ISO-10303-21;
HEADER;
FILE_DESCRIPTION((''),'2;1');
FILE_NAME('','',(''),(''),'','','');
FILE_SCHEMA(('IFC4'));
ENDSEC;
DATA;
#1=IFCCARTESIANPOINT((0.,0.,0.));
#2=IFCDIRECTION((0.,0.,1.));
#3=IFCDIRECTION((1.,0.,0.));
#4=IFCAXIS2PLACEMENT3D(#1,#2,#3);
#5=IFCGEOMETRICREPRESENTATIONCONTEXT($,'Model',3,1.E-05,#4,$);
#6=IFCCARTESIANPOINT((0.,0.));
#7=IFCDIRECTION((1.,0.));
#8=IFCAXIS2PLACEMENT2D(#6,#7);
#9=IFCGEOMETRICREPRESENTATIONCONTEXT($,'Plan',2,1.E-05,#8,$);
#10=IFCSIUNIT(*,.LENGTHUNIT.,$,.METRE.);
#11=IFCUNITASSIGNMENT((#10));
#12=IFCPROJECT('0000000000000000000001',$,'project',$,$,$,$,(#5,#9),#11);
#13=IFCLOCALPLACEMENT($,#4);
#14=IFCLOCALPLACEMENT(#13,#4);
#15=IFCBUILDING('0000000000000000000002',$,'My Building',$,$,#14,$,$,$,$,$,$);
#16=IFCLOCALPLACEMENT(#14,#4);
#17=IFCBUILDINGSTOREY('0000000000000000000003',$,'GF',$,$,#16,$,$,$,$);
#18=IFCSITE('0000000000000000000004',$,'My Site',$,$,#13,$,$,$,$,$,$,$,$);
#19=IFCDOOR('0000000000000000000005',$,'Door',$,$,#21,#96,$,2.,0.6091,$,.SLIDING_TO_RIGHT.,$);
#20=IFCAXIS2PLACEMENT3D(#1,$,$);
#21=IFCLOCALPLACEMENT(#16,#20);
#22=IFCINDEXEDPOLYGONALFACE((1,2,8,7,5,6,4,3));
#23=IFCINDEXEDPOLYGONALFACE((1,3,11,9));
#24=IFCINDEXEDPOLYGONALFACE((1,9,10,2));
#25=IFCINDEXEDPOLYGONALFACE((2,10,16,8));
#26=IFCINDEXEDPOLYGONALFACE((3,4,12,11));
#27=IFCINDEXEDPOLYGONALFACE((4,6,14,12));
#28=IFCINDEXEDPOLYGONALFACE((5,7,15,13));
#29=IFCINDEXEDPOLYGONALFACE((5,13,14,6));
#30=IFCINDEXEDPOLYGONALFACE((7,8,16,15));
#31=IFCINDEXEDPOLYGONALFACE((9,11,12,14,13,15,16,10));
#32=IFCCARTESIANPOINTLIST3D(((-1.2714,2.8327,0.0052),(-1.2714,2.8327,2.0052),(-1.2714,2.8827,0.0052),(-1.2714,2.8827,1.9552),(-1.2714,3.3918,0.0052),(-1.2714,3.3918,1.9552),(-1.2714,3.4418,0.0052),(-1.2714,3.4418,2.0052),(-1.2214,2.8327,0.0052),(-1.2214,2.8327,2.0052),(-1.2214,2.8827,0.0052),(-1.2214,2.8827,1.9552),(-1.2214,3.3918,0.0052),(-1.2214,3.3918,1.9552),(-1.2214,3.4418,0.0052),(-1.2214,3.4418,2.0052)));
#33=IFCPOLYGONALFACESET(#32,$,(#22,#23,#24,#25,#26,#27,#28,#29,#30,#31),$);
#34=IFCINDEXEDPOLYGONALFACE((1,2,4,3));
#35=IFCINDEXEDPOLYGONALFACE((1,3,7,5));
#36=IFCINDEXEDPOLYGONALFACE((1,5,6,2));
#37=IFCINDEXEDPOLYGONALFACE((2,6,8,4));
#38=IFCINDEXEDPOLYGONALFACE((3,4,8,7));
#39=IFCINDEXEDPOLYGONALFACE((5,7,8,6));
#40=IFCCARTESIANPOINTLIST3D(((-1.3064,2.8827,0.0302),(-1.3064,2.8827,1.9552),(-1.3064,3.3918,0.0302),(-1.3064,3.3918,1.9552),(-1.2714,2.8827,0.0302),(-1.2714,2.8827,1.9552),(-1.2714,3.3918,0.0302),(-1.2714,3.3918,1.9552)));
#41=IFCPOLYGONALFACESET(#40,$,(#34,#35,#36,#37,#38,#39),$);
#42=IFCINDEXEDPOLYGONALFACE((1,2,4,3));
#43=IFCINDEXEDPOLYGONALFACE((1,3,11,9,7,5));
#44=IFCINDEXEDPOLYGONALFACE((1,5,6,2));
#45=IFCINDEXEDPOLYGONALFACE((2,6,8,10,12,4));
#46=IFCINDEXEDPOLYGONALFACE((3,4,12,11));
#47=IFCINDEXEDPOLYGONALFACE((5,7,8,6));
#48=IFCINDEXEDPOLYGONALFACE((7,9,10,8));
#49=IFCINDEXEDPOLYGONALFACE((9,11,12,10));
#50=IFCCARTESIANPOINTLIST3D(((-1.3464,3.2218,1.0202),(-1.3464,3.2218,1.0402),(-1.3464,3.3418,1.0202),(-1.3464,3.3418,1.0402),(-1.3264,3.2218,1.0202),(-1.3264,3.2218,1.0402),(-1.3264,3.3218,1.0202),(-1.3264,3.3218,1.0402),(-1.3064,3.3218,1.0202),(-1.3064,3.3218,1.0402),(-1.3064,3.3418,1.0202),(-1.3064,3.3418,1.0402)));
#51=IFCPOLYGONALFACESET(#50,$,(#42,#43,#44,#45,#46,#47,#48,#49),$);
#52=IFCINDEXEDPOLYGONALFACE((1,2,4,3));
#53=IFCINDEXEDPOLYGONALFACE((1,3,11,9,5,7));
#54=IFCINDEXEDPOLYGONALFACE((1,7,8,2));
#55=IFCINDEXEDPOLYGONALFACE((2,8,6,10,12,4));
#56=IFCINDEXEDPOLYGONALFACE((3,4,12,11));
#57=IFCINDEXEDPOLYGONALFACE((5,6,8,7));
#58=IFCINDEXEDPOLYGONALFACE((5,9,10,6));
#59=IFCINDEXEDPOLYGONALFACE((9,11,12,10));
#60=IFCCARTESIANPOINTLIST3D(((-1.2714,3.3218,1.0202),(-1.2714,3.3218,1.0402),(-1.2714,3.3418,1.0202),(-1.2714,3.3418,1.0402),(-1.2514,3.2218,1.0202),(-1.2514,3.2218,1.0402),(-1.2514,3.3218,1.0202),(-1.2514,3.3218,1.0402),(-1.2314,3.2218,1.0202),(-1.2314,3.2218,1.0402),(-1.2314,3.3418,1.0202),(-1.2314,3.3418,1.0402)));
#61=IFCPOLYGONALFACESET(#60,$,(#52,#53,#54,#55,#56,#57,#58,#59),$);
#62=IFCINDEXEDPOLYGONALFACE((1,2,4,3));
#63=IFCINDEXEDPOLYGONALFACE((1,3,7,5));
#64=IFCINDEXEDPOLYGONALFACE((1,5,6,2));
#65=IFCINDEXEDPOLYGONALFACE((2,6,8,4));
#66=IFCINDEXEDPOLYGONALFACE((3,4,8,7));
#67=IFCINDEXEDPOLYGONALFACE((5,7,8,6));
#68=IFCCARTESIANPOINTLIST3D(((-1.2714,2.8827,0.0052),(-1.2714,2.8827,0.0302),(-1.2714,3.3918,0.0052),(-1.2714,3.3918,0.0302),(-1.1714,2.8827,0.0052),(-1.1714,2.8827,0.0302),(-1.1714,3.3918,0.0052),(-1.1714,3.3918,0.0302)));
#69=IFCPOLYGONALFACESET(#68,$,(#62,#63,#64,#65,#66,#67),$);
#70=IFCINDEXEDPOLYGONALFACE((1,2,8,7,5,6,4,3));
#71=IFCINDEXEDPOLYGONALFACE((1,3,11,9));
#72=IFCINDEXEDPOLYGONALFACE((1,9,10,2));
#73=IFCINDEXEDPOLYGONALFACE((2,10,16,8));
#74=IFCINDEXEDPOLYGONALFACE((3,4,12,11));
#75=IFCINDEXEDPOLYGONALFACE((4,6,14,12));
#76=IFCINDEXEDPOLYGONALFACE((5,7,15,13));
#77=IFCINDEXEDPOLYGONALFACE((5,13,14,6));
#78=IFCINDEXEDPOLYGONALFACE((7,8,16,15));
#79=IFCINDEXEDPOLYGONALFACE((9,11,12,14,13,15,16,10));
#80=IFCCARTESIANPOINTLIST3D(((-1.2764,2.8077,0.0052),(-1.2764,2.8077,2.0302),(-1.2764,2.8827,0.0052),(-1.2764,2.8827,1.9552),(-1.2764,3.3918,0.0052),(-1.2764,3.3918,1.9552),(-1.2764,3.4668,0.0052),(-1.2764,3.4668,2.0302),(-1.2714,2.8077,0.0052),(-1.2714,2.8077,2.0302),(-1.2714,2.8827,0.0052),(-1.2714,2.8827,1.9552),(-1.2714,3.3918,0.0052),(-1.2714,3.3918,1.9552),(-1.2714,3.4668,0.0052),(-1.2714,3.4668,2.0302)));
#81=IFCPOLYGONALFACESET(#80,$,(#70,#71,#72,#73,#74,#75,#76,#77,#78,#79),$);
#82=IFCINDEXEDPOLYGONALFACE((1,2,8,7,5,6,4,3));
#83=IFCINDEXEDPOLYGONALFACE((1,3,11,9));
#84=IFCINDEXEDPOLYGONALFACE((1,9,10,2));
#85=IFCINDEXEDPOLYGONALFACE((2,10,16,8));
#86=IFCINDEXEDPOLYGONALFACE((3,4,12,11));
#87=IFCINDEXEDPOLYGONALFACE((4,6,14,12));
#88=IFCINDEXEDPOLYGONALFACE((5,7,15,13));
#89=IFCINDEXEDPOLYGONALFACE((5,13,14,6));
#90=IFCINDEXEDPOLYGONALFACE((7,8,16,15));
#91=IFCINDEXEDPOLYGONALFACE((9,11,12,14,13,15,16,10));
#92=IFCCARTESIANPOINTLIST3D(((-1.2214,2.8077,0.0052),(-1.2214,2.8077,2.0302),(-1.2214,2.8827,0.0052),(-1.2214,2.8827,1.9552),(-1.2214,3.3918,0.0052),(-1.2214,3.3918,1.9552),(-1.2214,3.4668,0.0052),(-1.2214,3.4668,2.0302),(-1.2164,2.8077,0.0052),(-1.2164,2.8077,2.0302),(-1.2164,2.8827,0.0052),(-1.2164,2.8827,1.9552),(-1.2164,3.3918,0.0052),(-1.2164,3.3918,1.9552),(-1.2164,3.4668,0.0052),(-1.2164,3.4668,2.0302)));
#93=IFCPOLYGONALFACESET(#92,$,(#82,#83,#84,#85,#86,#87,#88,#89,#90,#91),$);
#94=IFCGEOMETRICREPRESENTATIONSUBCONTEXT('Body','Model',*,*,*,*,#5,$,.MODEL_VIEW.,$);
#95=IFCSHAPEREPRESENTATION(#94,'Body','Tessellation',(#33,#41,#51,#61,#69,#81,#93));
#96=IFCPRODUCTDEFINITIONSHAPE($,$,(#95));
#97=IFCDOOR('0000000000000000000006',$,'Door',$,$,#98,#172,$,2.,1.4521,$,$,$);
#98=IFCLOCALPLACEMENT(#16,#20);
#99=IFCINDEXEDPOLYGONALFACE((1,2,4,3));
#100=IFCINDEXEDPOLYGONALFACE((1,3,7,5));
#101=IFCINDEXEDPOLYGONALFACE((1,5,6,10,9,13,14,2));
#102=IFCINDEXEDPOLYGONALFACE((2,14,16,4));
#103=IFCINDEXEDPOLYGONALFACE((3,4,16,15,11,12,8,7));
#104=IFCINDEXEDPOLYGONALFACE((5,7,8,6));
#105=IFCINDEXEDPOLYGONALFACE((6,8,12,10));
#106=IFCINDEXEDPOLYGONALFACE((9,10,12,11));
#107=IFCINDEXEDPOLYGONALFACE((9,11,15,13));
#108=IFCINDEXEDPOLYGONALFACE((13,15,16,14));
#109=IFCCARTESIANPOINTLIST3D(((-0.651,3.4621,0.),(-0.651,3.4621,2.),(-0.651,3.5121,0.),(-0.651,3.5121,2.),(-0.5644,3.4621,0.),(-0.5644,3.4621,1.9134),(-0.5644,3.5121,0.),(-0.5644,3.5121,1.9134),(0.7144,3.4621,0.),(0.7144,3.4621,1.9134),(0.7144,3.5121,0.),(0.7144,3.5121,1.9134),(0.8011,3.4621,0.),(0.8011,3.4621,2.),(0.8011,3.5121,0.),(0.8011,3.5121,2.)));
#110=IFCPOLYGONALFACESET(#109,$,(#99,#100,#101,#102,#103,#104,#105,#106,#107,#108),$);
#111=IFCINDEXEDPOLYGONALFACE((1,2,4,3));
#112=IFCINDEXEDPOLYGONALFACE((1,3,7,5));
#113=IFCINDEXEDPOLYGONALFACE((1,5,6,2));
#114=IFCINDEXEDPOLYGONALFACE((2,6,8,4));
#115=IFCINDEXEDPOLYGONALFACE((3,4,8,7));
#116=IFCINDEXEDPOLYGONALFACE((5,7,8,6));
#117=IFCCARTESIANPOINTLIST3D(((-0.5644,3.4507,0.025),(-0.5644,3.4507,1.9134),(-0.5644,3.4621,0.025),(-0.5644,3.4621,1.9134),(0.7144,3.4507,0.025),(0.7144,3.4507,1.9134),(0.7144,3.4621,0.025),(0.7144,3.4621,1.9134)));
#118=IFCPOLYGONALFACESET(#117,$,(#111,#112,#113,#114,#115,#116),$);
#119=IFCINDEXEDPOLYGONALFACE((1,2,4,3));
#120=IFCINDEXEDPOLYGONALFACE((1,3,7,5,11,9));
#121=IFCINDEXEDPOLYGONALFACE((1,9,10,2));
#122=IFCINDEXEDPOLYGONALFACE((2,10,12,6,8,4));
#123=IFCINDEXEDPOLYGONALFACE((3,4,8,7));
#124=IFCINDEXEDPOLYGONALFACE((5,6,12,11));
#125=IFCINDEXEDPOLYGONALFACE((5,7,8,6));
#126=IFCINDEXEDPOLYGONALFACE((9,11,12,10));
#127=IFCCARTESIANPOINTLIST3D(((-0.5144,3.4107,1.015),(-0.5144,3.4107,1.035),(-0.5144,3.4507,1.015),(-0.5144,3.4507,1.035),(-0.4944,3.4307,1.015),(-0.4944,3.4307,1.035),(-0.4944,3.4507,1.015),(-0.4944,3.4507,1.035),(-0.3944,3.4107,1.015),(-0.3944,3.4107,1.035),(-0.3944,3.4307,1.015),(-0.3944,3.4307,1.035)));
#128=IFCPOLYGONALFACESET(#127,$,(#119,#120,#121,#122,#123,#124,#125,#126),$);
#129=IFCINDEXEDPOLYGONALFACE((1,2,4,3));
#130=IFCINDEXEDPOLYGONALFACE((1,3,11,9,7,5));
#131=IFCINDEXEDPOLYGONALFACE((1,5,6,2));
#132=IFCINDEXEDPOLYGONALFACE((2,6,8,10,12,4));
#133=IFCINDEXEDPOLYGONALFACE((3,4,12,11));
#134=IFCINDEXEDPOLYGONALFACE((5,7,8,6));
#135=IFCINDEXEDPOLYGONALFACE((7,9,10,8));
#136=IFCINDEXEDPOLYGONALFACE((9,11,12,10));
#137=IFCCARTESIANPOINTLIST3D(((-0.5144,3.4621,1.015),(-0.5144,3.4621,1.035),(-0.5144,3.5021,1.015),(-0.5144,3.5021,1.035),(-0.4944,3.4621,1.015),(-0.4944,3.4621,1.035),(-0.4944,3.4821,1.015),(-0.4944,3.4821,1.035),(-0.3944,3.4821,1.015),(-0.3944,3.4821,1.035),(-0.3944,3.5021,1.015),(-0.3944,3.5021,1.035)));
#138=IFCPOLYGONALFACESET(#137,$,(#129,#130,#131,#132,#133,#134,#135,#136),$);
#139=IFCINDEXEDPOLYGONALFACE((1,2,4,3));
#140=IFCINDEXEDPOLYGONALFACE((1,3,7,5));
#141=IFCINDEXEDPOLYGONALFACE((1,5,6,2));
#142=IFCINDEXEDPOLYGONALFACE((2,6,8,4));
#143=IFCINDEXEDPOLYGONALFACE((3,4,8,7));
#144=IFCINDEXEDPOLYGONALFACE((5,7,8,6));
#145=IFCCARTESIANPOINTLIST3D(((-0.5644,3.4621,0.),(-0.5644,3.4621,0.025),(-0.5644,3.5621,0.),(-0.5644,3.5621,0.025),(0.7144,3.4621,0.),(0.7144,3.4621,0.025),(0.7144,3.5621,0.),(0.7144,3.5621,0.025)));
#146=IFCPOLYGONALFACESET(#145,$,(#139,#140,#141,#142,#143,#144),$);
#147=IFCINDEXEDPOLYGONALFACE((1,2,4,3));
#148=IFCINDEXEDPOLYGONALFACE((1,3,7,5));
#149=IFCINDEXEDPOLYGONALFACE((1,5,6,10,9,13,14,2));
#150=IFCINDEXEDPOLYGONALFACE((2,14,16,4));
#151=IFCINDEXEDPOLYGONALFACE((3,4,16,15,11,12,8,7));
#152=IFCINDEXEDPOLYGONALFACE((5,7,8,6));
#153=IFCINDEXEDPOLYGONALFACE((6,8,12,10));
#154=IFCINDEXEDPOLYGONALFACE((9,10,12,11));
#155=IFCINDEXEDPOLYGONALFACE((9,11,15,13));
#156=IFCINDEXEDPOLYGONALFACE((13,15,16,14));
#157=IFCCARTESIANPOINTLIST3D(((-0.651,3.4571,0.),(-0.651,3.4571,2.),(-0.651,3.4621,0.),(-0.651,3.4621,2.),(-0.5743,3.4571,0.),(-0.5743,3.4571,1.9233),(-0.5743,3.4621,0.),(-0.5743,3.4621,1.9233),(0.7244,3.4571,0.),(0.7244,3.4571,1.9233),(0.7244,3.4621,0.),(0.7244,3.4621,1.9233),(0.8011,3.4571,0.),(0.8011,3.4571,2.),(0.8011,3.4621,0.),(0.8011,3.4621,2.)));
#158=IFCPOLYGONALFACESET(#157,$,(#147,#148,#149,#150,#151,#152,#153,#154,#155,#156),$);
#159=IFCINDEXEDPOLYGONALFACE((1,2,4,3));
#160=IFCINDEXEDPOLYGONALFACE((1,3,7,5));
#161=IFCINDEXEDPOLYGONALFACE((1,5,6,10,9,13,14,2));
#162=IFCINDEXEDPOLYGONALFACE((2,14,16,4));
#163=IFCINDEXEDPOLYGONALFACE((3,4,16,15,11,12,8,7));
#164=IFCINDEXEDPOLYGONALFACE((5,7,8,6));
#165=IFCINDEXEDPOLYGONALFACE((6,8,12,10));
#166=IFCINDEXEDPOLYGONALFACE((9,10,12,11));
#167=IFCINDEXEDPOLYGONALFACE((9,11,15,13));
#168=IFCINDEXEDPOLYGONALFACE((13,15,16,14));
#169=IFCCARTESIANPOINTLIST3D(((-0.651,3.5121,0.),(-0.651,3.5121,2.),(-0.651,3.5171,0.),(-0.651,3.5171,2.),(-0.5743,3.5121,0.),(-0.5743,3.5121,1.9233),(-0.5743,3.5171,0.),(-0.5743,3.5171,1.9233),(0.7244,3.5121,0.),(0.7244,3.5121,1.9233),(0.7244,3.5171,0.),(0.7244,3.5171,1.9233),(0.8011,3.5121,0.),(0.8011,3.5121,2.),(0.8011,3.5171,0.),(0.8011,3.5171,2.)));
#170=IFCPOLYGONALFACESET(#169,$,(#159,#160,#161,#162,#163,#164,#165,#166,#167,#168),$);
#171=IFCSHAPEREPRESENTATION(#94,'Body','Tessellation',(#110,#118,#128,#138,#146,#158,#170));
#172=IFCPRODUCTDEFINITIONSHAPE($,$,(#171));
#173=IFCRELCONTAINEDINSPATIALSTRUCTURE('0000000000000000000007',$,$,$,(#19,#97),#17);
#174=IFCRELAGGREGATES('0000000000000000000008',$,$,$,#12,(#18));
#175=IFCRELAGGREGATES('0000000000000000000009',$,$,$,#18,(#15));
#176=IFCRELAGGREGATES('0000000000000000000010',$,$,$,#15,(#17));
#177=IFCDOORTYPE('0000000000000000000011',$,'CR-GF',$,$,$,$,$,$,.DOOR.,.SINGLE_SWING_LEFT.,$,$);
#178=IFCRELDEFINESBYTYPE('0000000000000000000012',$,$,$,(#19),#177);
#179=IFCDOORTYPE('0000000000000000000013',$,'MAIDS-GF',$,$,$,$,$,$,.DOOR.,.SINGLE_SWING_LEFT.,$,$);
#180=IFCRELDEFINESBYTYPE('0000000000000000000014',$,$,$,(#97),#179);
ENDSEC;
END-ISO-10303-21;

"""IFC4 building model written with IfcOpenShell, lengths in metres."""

from ifc_helpers import new_model, entity, si_unit, frame, origin_with_axes, origin_2d_with_axis, place, context, subcontext, project, spatial, line, indexed_curve, outline, extrude, shape, source, transform, mapped, type_object, type_shapes, element, save


model = new_model("IFC4")

# Units and contexts
model_context = context("Model", 3, precision=1e-05, world=origin_with_axes())
plan_context = context("Plan", 2, precision=1e-05, world=origin_2d_with_axis())
body_context_1 = subcontext(model_context, "Body", "Model", "MODEL_VIEW")
body_context_2 = subcontext(plan_context, "Body", "Plan", "PLAN_VIEW")
ifc_project = project(units=[si_unit("LENGTHUNIT", "METRE")], contexts=[model_context, plan_context])

# Site, building, storey
site_placement = place(None, origin_with_axes())
site = spatial("IfcSite", under=ifc_project, at=site_placement, Name="My Site")
building_placement = place(site_placement, origin_with_axes())
building = spatial("IfcBuilding", under=site, at=building_placement, Name="My Building")
storey_placement = place(building_placement, origin_with_axes())
storey = spatial("IfcBuildingStorey", under=building, at=storey_placement, Name="GF")

# Shared definitions
wall_1_placement = place(storey_placement, frame((0.7783, 3.5621, 0.0), z_axis=(0.0, 0.0, 1.0), x_axis=(-1.0, 0.0, 0.0)))
door_type_1 = type_object("IfcDoorType", Name="MAIDS-GF", OperationType="SINGLE_SWING_LEFT", PredefinedType="DOOR")
shared_shape_1 = source(origin_with_axes(), body_context_1, "Body", "SweptSolid", [
    extrude(outline(indexed_curve([(0.0, 0.0), (0.0, 2.0), (1.4521, 2.0), (1.4521, 0.0), (1.3655, 0.0), (1.3655, 1.9134), (0.0866, 1.9134), (0.0866, 0.0)], segments=[line(1, 2, 3, 4, 5, 6, 7, 8, 1)])), frame((0.0, 0.0, 0.0), z_axis=(0.0, -1.0, 0.0), x_axis=(1.0, 0.0, 0.0)), (0.0, 0.0, -1.0), 0.05),
    extrude(outline(indexed_curve([(0.0, 0.0), (1.2788, 0.0), (1.2788, 0.0114), (0.0, 0.0114)], segments=[line(1, 2, 3, 4, 1)])), frame((0.0866, -0.0114, 0.025), z_axis=(0.0, 0.0, 1.0), x_axis=(1.0, 0.0, 0.0)), (0.0, 0.0, 1.0), 1.8884),
    extrude(outline(indexed_curve([(0.0, 0.0), (0.0, -0.04), (0.12, -0.04), (0.12, -0.02), (0.02, -0.02), (0.02, 0.0)], segments=[line(1, 2, 3, 4, 5, 6, 1)])), frame((0.1366, -0.0114, 1.015), z_axis=(0.0, 0.0, 1.0), x_axis=(1.0, 0.0, 0.0)), (0.0, 0.0, 1.0), 0.02),
    extrude(outline(indexed_curve([(0.0, 0.0), (0.0, 0.04), (0.12, 0.04), (0.12, 0.02), (0.02, 0.02), (0.02, 0.0)], segments=[line(1, 2, 3, 4, 5, 6, 1)])), frame((0.1366, 0.0, 1.015), z_axis=(0.0, 0.0, 1.0), x_axis=(1.0, 0.0, 0.0)), (0.0, 0.0, 1.0), 0.02),
    extrude(outline(indexed_curve([(0.0, 0.0), (1.2788, 0.0), (1.2788, 0.1), (0.0, 0.1)], segments=[line(1, 2, 3, 4, 1)])), frame((0.0866, 0.0, 0.0), z_axis=(0.0, 0.0, 1.0), x_axis=(1.0, 0.0, 0.0)), (0.0, 0.0, 1.0), 0.025),
    extrude(outline(indexed_curve([(0.0, 0.0), (0.0, 2.0), (1.4521, 2.0), (1.4521, 0.0), (1.3754, 0.0), (1.3754, 1.9233), (0.0767, 1.9233), (0.0767, 0.0)], segments=[line(1, 2, 3, 4, 5, 6, 7, 8, 1)])), frame((0.0, -0.005, 0.0), z_axis=(0.0, -1.0, 0.0), x_axis=(1.0, 0.0, 0.0)), (0.0, 0.0, -1.0), 0.005),
    extrude(outline(indexed_curve([(0.0, 0.0), (0.0, 2.0), (1.4521, 2.0), (1.4521, 0.0), (1.3754, 0.0), (1.3754, 1.9233), (0.0767, 1.9233), (0.0767, 0.0)], segments=[line(1, 2, 3, 4, 5, 6, 7, 8, 1)])), frame((0.0, 0.05, 0.0), z_axis=(0.0, -1.0, 0.0), x_axis=(1.0, 0.0, 0.0)), (0.0, 0.0, -1.0), 0.005),
])
shared_shape_2 = source(origin_with_axes(), body_context_2, "Body", "Curve2D", [
    entity("IfcIndexedPolyCurve", entity("IfcCartesianPointList2D", [[0.0, 0.0], [0.0866, 0.0], [0.0866, 0.05], [0.0, 0.05]]), [entity("IfcLineIndex", [1, 2, 3, 4, 1])]),
    entity("IfcIndexedPolyCurve", entity("IfcCartesianPointList2D", [[1.4521, 0.0], [1.3655, 0.0], [1.3655, 0.05], [1.4521, 0.05]]), [entity("IfcLineIndex", [1, 2, 3, 4, 1])]),
    entity("IfcIndexedPolyCurve", entity("IfcCartesianPointList2D", [[2.0049, -0.0114], [0.7261, -0.0114], [0.7261, 0.0], [2.0049, 0.0]]), [entity("IfcLineIndex", [1, 2, 3, 4, 1])]),
])
type_shapes(door_type_1, [shared_shape_1, shared_shape_2])

# Doors
door_type_2 = type_object("IfcDoorType", Name="CR-GF", OperationType="SINGLE_SWING_LEFT", PredefinedType="DOOR")
shared_shape_3 = source(origin_with_axes(), body_context_1, "Body", "SweptSolid", [
    extrude(outline(indexed_curve([(0.0, 0.0), (0.0, 2.0), (0.6091, 2.0), (0.6091, 0.0), (0.5591, 0.0), (0.5591, 1.95), (0.05, 1.95), (0.05, 0.0)], segments=[line(1, 2, 3, 4, 5, 6, 7, 8, 1)])), frame((0.0, 0.0, 0.0), z_axis=(0.0, -1.0, 0.0), x_axis=(1.0, 0.0, 0.0)), (0.0, 0.0, -1.0), 0.05),
    extrude(outline(indexed_curve([(0.0, 0.0), (0.5091, 0.0), (0.5091, 0.035), (0.0, 0.035)], segments=[line(1, 2, 3, 4, 1)])), frame((0.05, -0.035, 0.025), z_axis=(0.0, 0.0, 1.0), x_axis=(1.0, 0.0, 0.0)), (0.0, 0.0, 1.0), 1.925),
    extrude(outline(indexed_curve([(0.0, 0.0), (0.0, -0.04), (0.12, -0.04), (0.12, -0.02), (0.02, -0.02), (0.02, 0.0)], segments=[line(1, 2, 3, 4, 5, 6, 1)])), frame((0.1, -0.035, 1.015), z_axis=(0.0, 0.0, 1.0), x_axis=(1.0, 0.0, 0.0)), (0.0, 0.0, 1.0), 0.02),
    extrude(outline(indexed_curve([(0.0, 0.0), (0.0, 0.04), (0.12, 0.04), (0.12, 0.02), (0.02, 0.02), (0.02, 0.0)], segments=[line(1, 2, 3, 4, 5, 6, 1)])), frame((0.1, 0.0, 1.015), z_axis=(0.0, 0.0, 1.0), x_axis=(1.0, 0.0, 0.0)), (0.0, 0.0, 1.0), 0.02),
    extrude(outline(indexed_curve([(0.0, 0.0), (0.5091, 0.0), (0.5091, 0.1), (0.0, 0.1)], segments=[line(1, 2, 3, 4, 1)])), frame((0.05, 0.0, 0.0), z_axis=(0.0, 0.0, 1.0), x_axis=(1.0, 0.0, 0.0)), (0.0, 0.0, 1.0), 0.025),
    extrude(outline(indexed_curve([(0.0, 0.0), (0.0, 2.025), (0.6591, 2.025), (0.6591, 0.0), (0.5841, 0.0), (0.5841, 1.95), (0.075, 1.95), (0.075, 0.0)], segments=[line(1, 2, 3, 4, 5, 6, 7, 8, 1)])), frame((-0.025, -0.005, 0.0), z_axis=(0.0, -1.0, 0.0), x_axis=(1.0, 0.0, 0.0)), (0.0, 0.0, -1.0), 0.005),
    extrude(outline(indexed_curve([(0.0, 0.0), (0.0, 2.025), (0.6591, 2.025), (0.6591, 0.0), (0.5841, 0.0), (0.5841, 1.95), (0.075, 1.95), (0.075, 0.0)], segments=[line(1, 2, 3, 4, 5, 6, 7, 8, 1)])), frame((-0.025, 0.05, 0.0), z_axis=(0.0, -1.0, 0.0), x_axis=(1.0, 0.0, 0.0)), (0.0, 0.0, -1.0), 0.005),
])
shared_shape_4 = source(origin_with_axes(), body_context_2, "Body", "Curve2D", [
    entity("IfcIndexedPolyCurve", entity("IfcCartesianPointList2D", [[0.0, 0.0], [0.05, 0.0], [0.05, 0.05], [0.0, 0.05]]), [entity("IfcLineIndex", [1, 2, 3, 4, 1])]),
    entity("IfcIndexedPolyCurve", entity("IfcCartesianPointList2D", [[0.6091, 0.0], [0.5591, 0.0], [0.5591, 0.05], [0.6091, 0.05]]), [entity("IfcLineIndex", [1, 2, 3, 4, 1])]),
    entity("IfcIndexedPolyCurve", entity("IfcCartesianPointList2D", [[0.8137, -0.035], [0.3046, -0.035], [0.3046, 0.0], [0.8137, 0.0]]), [entity("IfcLineIndex", [1, 2, 3, 4, 1])]),
])
type_shapes(door_type_2, [shared_shape_3, shared_shape_4])
placement_1 = place(storey_placement, frame((-1.1836, 2.64, 0.0), z_axis=(0.0, 0.0, 1.0), x_axis=(0.0, 1.0, 0.0)))
placement_2 = place(placement_1, frame((0.8018, 0.0877, 0.0052), z_axis=(0.0, 0.0, 1.0), x_axis=(-1.0, 0.0, 0.0)))
door_1_placement = place(placement_2, frame((0.0, 0.0, 0.0), z_axis=(0.0, 0.0, 1.0), x_axis=(1.0, 0.0, 0.0)))
element("IfcDoor", 1, at=door_1_placement, inside=storey, type_object=door_type_2, Name="Door", OperationType="SLIDING_TO_RIGHT", OverallHeight=2.0, OverallWidth=0.6091, shapes=[
    shape(body_context_1, "Body", "MappedRepresentation", [mapped(shared_shape_3, transform((0.0, 0.0, 0.0), x_axis=(1.0, 0.0, 0.0), y_axis=(0.0, 1.0, 0.0), z_axis=(0.0, 0.0, 1.0), scale=1.0))]),
    shape(body_context_2, "Body", "MappedRepresentation", [mapped(shared_shape_4, transform((0.0, 0.0, 0.0), x_axis=(1.0, 0.0, 0.0), y_axis=(0.0, 1.0, 0.0), z_axis=(0.0, 0.0, 1.0), scale=1.0))]),
])
placement_3 = place(wall_1_placement, frame((1.4294, 0.1, 0.0), z_axis=(0.0, 0.0, 1.0), x_axis=(-1.0, 0.0, 0.0)))
door_2_placement = place(placement_3, frame((0.0, 0.0, 0.0), z_axis=(0.0, 0.0, 1.0), x_axis=(1.0, 0.0, 0.0)))
element("IfcDoor", 2, at=door_2_placement, inside=storey, type_object=door_type_1, Name="Door", OverallHeight=2.0, OverallWidth=1.4521, shapes=[
    shape(body_context_1, "Body", "MappedRepresentation", [mapped(shared_shape_1, transform((0.0, 0.0, 0.0), x_axis=(1.0, 0.0, 0.0), y_axis=(0.0, 1.0, 0.0), z_axis=(0.0, 0.0, 1.0), scale=1.0))]),
    shape(body_context_2, "Body", "MappedRepresentation", [mapped(shared_shape_2, transform((0.0, 0.0, 0.0), x_axis=(1.0, 0.0, 0.0), y_axis=(0.0, 1.0, 0.0), z_axis=(0.0, 0.0, 1.0), scale=1.0))]),
])

save(model, "model.ifc")
